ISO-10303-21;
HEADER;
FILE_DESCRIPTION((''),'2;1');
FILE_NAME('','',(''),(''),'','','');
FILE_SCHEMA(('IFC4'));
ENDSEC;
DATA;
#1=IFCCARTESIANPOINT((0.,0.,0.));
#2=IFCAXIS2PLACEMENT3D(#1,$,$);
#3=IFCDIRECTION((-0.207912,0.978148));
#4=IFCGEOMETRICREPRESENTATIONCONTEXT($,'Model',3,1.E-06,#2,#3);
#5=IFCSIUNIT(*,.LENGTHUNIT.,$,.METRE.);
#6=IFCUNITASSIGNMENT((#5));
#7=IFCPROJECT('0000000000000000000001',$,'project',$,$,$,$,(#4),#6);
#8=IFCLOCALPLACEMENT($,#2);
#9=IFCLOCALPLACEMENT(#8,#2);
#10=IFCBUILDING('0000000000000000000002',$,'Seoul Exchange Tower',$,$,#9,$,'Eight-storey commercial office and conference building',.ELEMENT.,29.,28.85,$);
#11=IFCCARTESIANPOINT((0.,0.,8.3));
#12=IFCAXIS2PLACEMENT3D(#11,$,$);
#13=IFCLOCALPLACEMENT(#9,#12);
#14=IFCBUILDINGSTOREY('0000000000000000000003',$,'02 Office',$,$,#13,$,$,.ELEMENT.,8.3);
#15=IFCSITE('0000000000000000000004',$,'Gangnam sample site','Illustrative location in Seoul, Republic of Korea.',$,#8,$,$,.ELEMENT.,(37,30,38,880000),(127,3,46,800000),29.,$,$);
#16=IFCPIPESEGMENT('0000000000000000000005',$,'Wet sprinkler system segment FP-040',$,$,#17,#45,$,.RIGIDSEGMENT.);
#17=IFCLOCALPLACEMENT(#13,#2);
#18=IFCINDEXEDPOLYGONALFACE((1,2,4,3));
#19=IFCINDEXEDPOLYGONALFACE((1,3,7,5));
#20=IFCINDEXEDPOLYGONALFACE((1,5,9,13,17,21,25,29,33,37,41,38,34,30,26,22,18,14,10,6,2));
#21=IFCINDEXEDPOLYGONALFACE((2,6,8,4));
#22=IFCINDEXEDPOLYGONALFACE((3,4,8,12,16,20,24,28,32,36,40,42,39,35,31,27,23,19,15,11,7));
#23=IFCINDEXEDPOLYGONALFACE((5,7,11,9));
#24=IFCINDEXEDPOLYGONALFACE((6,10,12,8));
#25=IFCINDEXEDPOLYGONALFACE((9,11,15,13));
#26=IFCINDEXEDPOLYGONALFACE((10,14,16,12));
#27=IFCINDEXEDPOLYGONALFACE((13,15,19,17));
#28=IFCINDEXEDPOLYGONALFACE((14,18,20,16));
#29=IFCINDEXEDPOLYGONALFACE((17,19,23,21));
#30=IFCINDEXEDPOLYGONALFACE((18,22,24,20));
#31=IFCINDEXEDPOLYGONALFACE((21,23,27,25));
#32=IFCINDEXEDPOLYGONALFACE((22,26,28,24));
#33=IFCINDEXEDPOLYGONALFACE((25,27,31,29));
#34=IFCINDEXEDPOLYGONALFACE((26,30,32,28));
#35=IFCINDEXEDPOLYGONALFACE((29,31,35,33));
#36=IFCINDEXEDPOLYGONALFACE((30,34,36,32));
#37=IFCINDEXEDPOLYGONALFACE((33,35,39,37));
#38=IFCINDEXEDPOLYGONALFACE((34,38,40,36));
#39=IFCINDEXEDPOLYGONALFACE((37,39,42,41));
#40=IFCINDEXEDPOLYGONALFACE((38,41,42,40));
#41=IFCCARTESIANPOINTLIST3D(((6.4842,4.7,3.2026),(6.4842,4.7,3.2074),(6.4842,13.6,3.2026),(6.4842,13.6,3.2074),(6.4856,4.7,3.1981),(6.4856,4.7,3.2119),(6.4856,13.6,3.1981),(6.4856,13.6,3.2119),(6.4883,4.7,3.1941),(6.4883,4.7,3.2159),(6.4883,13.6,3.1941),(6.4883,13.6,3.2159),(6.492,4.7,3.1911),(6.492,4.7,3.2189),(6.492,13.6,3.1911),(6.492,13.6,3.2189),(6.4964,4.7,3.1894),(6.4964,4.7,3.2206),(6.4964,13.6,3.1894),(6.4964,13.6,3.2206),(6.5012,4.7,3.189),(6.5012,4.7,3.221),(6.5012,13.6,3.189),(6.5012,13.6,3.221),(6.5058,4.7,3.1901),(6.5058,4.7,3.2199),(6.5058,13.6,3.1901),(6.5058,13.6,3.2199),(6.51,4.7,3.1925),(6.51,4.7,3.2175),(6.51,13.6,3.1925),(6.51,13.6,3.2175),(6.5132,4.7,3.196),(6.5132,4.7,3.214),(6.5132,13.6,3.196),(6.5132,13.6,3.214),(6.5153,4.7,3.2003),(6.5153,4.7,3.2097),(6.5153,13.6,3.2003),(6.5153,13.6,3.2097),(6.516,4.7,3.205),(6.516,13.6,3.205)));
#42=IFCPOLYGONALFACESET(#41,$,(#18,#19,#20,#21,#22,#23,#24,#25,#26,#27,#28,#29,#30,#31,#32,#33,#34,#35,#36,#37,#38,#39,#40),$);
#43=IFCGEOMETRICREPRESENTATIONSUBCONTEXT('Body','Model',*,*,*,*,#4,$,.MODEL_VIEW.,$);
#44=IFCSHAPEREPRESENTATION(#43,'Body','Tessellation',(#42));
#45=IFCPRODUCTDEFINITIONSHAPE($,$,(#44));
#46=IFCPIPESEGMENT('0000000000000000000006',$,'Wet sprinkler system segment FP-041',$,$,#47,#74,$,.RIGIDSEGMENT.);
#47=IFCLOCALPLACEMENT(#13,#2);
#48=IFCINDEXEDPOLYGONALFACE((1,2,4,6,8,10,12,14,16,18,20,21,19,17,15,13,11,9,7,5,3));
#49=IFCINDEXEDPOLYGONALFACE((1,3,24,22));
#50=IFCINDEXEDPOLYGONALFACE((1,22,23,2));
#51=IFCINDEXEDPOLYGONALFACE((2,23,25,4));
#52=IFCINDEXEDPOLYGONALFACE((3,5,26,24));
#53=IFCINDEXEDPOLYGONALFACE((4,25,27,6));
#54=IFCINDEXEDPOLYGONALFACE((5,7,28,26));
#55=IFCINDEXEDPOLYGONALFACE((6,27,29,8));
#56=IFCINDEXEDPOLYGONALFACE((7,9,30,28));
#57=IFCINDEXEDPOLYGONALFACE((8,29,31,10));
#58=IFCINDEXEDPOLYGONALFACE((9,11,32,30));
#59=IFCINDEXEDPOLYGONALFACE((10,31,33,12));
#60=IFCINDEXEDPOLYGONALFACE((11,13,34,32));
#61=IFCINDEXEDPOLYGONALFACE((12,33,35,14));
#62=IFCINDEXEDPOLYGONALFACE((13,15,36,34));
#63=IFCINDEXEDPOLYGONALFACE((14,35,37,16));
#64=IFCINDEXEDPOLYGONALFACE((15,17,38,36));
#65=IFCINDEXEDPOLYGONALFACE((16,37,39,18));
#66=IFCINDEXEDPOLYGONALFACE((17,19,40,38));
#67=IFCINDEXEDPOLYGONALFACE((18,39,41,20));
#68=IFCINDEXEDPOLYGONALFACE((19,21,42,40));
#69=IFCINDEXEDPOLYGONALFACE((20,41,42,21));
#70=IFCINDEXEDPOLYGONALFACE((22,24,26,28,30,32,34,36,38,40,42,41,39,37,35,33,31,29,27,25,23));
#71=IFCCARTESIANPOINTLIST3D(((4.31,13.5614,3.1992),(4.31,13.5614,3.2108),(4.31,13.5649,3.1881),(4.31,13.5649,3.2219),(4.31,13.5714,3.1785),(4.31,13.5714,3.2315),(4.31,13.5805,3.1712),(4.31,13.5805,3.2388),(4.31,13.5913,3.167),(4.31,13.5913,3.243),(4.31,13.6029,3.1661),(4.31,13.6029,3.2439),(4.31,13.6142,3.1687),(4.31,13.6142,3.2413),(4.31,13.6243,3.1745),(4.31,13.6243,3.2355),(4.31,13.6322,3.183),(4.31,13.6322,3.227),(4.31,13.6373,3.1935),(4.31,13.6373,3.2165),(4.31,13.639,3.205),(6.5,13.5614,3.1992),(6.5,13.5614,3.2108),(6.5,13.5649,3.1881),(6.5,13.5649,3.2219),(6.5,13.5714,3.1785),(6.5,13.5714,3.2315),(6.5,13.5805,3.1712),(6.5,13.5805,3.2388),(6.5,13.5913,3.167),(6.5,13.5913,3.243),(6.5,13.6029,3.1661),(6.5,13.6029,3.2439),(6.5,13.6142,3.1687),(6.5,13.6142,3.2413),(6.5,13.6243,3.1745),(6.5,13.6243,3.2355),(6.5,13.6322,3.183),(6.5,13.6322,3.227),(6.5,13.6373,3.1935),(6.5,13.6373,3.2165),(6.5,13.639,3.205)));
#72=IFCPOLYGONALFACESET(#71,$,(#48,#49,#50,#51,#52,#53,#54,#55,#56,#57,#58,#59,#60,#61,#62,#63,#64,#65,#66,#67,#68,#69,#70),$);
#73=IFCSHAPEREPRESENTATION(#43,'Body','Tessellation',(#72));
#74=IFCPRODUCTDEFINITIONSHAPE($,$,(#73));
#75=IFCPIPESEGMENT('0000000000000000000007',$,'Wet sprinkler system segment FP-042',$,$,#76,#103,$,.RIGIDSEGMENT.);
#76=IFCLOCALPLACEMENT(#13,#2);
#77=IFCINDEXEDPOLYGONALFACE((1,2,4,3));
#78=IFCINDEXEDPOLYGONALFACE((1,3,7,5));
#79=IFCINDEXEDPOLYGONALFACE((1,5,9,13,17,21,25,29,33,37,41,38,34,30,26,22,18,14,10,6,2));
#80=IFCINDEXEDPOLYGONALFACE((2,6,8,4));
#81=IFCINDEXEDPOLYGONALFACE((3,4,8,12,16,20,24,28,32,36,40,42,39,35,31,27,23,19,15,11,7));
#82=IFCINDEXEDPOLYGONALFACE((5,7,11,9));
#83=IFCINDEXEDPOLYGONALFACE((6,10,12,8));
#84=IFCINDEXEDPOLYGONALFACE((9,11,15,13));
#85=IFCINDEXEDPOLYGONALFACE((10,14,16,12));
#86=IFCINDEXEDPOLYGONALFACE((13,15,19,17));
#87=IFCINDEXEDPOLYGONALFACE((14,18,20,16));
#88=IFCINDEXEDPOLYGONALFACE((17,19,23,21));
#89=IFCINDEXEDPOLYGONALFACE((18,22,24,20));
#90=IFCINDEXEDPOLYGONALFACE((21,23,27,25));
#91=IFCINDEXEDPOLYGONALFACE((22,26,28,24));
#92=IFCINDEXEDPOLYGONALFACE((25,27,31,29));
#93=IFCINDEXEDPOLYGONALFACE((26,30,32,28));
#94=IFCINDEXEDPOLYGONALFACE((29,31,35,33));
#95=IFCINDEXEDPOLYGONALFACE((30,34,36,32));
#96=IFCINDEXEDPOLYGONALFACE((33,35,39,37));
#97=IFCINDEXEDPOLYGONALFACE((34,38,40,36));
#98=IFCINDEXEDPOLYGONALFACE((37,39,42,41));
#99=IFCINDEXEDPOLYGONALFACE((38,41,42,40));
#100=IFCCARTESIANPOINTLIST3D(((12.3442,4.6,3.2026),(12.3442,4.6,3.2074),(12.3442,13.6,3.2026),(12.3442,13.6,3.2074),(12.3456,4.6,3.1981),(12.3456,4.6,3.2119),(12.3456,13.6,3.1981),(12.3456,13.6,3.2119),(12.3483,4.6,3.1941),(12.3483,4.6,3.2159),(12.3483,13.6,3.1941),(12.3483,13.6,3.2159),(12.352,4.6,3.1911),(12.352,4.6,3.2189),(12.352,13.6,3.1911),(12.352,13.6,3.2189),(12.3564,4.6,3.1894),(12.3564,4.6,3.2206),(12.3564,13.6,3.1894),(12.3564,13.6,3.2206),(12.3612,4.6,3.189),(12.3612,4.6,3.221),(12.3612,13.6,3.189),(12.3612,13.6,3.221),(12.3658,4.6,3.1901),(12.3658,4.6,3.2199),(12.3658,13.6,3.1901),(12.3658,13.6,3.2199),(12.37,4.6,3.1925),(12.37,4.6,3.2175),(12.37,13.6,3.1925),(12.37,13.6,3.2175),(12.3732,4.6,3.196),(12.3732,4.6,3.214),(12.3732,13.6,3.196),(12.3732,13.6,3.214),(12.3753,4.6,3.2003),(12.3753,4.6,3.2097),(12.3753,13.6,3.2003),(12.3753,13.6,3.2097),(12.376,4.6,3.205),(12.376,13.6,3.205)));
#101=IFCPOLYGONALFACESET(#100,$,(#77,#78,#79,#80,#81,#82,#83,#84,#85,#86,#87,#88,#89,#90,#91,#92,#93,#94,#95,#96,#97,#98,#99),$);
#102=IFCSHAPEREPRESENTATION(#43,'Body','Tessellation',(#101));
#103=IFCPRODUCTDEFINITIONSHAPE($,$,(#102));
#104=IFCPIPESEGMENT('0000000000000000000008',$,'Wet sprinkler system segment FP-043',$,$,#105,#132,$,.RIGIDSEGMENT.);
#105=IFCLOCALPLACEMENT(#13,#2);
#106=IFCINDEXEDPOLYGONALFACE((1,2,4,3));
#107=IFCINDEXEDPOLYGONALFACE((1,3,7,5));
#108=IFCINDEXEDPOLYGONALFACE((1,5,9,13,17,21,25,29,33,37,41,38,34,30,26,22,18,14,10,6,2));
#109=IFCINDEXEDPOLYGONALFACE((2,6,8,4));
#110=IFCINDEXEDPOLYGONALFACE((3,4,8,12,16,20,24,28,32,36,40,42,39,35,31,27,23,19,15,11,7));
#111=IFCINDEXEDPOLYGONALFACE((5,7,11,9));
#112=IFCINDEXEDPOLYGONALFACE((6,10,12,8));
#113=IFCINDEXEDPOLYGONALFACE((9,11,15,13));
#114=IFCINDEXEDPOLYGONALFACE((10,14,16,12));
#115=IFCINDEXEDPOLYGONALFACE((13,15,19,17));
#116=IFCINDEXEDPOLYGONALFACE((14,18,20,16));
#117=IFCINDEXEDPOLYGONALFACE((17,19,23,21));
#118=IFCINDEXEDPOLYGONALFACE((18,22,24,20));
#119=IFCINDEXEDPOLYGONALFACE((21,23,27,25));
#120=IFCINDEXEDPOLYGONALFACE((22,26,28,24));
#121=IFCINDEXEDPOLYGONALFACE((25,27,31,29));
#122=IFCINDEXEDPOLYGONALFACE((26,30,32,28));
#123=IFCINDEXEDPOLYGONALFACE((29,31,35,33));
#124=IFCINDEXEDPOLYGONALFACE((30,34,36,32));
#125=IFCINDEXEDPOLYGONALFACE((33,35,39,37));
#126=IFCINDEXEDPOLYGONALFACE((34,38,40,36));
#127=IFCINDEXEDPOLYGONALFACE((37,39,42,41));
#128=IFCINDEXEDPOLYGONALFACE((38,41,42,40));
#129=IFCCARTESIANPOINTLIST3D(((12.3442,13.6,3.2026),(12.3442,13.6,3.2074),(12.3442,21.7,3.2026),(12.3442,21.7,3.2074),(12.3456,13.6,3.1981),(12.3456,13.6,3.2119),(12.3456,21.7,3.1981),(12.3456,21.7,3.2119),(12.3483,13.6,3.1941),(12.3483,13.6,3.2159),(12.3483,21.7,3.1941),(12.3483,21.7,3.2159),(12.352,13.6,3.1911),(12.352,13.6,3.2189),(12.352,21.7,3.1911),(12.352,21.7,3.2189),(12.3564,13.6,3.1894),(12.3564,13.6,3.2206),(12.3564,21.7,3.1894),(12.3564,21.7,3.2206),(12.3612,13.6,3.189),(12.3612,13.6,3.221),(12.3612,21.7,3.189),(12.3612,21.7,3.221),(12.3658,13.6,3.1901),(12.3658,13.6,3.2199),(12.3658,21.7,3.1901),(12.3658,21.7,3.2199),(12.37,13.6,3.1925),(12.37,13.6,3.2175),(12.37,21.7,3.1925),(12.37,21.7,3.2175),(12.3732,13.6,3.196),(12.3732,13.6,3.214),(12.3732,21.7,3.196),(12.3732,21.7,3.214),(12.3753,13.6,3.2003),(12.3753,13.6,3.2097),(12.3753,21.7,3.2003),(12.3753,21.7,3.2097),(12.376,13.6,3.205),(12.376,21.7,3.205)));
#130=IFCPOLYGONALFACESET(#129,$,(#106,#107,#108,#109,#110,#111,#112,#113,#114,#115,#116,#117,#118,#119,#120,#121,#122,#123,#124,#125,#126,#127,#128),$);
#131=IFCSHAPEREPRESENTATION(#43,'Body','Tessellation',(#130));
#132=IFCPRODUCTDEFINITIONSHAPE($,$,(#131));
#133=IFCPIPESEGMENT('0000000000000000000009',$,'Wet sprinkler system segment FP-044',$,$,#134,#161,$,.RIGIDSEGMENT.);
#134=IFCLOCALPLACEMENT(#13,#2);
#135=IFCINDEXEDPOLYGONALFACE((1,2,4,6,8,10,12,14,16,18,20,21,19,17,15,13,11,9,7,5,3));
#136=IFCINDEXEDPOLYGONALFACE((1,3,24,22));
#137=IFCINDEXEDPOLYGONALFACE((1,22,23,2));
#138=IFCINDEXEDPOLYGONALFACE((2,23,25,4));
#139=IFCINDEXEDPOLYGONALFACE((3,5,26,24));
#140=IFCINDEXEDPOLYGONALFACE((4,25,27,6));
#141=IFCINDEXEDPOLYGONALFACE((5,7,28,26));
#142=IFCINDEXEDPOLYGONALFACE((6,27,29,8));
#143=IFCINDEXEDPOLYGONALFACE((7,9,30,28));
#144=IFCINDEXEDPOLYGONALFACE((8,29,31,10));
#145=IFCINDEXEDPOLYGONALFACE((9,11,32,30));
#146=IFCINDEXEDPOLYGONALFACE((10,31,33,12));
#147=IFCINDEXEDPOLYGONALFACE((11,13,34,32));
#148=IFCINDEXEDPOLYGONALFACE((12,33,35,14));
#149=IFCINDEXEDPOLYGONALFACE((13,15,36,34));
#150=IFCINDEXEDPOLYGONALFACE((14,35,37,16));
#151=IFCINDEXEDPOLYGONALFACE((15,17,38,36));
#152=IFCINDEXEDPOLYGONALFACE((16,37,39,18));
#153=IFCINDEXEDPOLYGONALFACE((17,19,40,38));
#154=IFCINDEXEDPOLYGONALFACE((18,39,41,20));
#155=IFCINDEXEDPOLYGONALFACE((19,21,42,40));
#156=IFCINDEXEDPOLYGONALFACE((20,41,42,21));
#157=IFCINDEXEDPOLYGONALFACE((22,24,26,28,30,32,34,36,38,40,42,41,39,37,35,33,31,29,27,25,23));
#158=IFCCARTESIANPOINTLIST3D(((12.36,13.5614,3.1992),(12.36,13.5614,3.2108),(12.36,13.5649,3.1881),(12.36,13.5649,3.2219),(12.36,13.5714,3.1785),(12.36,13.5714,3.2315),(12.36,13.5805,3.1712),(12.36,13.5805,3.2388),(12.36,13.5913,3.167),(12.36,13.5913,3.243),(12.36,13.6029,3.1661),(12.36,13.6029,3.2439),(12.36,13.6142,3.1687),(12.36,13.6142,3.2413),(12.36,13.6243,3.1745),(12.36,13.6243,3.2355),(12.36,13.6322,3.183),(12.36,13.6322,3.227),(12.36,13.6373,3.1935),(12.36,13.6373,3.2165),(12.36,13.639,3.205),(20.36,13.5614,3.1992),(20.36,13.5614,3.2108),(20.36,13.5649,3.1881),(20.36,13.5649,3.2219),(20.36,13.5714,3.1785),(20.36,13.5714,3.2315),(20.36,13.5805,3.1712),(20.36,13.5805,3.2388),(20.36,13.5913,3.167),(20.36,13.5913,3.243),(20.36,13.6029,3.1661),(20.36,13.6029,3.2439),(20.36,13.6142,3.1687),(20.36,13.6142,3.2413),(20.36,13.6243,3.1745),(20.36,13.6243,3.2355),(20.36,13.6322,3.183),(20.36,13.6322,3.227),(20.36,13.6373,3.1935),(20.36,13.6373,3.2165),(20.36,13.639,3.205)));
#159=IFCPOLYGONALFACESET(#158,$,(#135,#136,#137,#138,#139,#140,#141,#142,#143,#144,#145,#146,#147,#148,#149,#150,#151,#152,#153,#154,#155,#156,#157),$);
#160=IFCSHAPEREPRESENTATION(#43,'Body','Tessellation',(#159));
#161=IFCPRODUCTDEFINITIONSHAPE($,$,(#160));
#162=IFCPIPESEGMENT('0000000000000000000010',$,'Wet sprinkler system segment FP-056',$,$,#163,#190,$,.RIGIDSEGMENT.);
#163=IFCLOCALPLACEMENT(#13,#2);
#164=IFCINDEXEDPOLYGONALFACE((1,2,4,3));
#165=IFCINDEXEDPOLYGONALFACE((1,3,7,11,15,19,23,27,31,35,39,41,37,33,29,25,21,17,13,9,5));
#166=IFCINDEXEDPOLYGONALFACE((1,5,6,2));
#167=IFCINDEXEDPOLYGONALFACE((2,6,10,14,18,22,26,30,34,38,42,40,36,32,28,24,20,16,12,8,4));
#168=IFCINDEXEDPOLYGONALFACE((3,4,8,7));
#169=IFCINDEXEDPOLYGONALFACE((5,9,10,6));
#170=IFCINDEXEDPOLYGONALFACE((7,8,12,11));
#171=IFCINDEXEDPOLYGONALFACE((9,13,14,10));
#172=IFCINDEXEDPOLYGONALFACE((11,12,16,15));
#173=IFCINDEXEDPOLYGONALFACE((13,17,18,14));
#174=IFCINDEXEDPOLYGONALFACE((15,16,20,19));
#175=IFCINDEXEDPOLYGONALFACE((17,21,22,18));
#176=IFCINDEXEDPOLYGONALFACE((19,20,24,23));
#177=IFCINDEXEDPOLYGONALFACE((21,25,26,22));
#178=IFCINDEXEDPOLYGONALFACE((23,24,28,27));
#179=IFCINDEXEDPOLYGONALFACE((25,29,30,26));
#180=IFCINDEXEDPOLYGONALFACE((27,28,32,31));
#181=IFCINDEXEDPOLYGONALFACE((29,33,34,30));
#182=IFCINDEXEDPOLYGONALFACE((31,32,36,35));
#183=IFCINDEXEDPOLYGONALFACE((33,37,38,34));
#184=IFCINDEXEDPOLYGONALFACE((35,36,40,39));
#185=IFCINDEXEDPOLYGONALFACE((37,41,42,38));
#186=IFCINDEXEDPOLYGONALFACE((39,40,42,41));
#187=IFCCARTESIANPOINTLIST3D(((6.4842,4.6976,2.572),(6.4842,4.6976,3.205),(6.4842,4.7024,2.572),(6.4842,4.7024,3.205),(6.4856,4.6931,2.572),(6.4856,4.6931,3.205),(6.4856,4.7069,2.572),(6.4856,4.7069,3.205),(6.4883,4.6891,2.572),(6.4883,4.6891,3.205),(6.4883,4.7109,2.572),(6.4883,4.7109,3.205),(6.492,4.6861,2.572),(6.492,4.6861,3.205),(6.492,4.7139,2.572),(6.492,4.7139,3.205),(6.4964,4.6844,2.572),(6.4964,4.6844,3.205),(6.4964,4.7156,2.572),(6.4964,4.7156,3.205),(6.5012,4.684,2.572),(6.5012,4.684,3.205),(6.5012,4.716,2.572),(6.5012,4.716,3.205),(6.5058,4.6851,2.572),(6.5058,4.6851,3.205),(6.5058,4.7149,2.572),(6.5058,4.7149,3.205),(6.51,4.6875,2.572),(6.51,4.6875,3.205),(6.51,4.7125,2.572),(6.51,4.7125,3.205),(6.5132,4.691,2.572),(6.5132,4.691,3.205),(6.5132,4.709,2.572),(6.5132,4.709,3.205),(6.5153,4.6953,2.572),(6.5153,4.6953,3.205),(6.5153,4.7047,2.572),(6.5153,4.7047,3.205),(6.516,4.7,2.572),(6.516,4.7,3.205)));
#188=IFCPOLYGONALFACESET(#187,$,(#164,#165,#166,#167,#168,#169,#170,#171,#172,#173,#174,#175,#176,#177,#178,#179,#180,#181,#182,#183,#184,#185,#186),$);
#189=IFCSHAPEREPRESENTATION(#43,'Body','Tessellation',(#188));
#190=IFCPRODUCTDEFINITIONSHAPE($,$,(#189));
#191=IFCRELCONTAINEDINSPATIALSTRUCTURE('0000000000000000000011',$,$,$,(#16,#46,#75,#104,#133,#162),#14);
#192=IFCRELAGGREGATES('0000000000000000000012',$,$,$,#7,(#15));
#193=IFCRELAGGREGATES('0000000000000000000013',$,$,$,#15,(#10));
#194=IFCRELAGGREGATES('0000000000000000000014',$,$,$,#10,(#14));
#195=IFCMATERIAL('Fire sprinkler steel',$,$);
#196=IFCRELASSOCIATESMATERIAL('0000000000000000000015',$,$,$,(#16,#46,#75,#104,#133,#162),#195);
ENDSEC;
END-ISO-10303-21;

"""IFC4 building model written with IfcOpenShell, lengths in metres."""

from ifc_helpers import new_model, si_unit, direction, frame, origin, place, context, subcontext, project, spatial, circle, extrude, material, element, save


model = new_model("IFC4")

# Units and contexts
model_context = context("Model", 3, precision=1e-06, world=origin(), true_north=direction((-0.207912, 0.978148)))
body_context = subcontext(model_context, "Body", "Model", "MODEL_VIEW")
ifc_project = project(units=[si_unit("LENGTHUNIT", "METRE")], contexts=[model_context])

# Site, building, storey
site_placement = place(None, origin())
site = spatial("IfcSite", under=ifc_project, at=site_placement, Name="Gangnam sample site", Description="Illustrative location in Seoul, Republic of Korea.", CompositionType="ELEMENT", RefLatitude=(37, 30, 38, 880000), RefLongitude=(127, 3, 46, 800000), RefElevation=29.0)
building_placement = place(site_placement, origin())
building = spatial("IfcBuilding", under=site, at=building_placement, Name="Seoul Exchange Tower", LongName="Eight-storey commercial office and conference building", CompositionType="ELEMENT", ElevationOfRefHeight=29.0, ElevationOfTerrain=28.85)
storey_placement = place(building_placement, frame((0.0, 0.0, 8.3)))
storey = spatial("IfcBuildingStorey", under=building, at=storey_placement, Name="02 Office", CompositionType="ELEMENT", Elevation=8.3)

# Shared definitions
ifc_material = material(Name="Fire sprinkler steel")
placement = place(storey_placement, origin())

# Pipe segments
element("IfcPipeSegment", 1, at=placement, inside=storey, material=ifc_material, Name="Wet sprinkler system segment FP-040", PredefinedType="RIGIDSEGMENT", context=body_context, shape_type="SweptSolid", body=[
    extrude(circle(Radius=0.016), frame((6.5, 13.6, 3.205), z_axis=(0.0, -1.0, 0.0), x_axis=(1.0, 0.0, 0.0)), (0.0, 0.0, 1.0), 8.9),
])
element("IfcPipeSegment", 2, at=placement, inside=storey, material=ifc_material, Name="Wet sprinkler system segment FP-041", PredefinedType="RIGIDSEGMENT", context=body_context, shape_type="SweptSolid", body=[
    extrude(circle(Radius=0.039), frame((6.5, 13.6, 3.205), z_axis=(-1.0, 0.0, 0.0), x_axis=(0.0, 1.0, 0.0)), (0.0, 0.0, 1.0), 2.19),
])
element("IfcPipeSegment", 3, at=placement, inside=storey, material=ifc_material, Name="Wet sprinkler system segment FP-042", PredefinedType="RIGIDSEGMENT", context=body_context, shape_type="SweptSolid", body=[
    extrude(circle(Radius=0.016), frame((12.36, 13.6, 3.205), z_axis=(0.0, -1.0, 0.0), x_axis=(1.0, 0.0, 0.0)), (0.0, 0.0, 1.0), 9.0),
])
element("IfcPipeSegment", 4, at=placement, inside=storey, material=ifc_material, Name="Wet sprinkler system segment FP-043", PredefinedType="RIGIDSEGMENT", context=body_context, shape_type="SweptSolid", body=[
    extrude(circle(Radius=0.016), frame((12.36, 13.6, 3.205), z_axis=(0.0, 1.0, 0.0), x_axis=(1.0, 0.0, 0.0)), (0.0, 0.0, 1.0), 8.1),
])
element("IfcPipeSegment", 5, at=placement, inside=storey, material=ifc_material, Name="Wet sprinkler system segment FP-044", PredefinedType="RIGIDSEGMENT", context=body_context, shape_type="SweptSolid", body=[
    extrude(circle(Radius=0.039), frame((12.36, 13.6, 3.205), z_axis=(1.0, 0.0, 0.0), x_axis=(0.0, 1.0, 0.0)), (0.0, 0.0, 1.0), 8.0),
])
element("IfcPipeSegment", 6, at=placement, inside=storey, material=ifc_material, Name="Wet sprinkler system segment FP-056", PredefinedType="RIGIDSEGMENT", context=body_context, shape_type="SweptSolid", body=[
    extrude(circle(Radius=0.016), frame((6.5, 4.7, 3.205), z_axis=(0.0, 0.0, -1.0), x_axis=(1.0, 0.0, 0.0)), (0.0, 0.0, 1.0), 0.633),
])

save(model, "model.ifc")
